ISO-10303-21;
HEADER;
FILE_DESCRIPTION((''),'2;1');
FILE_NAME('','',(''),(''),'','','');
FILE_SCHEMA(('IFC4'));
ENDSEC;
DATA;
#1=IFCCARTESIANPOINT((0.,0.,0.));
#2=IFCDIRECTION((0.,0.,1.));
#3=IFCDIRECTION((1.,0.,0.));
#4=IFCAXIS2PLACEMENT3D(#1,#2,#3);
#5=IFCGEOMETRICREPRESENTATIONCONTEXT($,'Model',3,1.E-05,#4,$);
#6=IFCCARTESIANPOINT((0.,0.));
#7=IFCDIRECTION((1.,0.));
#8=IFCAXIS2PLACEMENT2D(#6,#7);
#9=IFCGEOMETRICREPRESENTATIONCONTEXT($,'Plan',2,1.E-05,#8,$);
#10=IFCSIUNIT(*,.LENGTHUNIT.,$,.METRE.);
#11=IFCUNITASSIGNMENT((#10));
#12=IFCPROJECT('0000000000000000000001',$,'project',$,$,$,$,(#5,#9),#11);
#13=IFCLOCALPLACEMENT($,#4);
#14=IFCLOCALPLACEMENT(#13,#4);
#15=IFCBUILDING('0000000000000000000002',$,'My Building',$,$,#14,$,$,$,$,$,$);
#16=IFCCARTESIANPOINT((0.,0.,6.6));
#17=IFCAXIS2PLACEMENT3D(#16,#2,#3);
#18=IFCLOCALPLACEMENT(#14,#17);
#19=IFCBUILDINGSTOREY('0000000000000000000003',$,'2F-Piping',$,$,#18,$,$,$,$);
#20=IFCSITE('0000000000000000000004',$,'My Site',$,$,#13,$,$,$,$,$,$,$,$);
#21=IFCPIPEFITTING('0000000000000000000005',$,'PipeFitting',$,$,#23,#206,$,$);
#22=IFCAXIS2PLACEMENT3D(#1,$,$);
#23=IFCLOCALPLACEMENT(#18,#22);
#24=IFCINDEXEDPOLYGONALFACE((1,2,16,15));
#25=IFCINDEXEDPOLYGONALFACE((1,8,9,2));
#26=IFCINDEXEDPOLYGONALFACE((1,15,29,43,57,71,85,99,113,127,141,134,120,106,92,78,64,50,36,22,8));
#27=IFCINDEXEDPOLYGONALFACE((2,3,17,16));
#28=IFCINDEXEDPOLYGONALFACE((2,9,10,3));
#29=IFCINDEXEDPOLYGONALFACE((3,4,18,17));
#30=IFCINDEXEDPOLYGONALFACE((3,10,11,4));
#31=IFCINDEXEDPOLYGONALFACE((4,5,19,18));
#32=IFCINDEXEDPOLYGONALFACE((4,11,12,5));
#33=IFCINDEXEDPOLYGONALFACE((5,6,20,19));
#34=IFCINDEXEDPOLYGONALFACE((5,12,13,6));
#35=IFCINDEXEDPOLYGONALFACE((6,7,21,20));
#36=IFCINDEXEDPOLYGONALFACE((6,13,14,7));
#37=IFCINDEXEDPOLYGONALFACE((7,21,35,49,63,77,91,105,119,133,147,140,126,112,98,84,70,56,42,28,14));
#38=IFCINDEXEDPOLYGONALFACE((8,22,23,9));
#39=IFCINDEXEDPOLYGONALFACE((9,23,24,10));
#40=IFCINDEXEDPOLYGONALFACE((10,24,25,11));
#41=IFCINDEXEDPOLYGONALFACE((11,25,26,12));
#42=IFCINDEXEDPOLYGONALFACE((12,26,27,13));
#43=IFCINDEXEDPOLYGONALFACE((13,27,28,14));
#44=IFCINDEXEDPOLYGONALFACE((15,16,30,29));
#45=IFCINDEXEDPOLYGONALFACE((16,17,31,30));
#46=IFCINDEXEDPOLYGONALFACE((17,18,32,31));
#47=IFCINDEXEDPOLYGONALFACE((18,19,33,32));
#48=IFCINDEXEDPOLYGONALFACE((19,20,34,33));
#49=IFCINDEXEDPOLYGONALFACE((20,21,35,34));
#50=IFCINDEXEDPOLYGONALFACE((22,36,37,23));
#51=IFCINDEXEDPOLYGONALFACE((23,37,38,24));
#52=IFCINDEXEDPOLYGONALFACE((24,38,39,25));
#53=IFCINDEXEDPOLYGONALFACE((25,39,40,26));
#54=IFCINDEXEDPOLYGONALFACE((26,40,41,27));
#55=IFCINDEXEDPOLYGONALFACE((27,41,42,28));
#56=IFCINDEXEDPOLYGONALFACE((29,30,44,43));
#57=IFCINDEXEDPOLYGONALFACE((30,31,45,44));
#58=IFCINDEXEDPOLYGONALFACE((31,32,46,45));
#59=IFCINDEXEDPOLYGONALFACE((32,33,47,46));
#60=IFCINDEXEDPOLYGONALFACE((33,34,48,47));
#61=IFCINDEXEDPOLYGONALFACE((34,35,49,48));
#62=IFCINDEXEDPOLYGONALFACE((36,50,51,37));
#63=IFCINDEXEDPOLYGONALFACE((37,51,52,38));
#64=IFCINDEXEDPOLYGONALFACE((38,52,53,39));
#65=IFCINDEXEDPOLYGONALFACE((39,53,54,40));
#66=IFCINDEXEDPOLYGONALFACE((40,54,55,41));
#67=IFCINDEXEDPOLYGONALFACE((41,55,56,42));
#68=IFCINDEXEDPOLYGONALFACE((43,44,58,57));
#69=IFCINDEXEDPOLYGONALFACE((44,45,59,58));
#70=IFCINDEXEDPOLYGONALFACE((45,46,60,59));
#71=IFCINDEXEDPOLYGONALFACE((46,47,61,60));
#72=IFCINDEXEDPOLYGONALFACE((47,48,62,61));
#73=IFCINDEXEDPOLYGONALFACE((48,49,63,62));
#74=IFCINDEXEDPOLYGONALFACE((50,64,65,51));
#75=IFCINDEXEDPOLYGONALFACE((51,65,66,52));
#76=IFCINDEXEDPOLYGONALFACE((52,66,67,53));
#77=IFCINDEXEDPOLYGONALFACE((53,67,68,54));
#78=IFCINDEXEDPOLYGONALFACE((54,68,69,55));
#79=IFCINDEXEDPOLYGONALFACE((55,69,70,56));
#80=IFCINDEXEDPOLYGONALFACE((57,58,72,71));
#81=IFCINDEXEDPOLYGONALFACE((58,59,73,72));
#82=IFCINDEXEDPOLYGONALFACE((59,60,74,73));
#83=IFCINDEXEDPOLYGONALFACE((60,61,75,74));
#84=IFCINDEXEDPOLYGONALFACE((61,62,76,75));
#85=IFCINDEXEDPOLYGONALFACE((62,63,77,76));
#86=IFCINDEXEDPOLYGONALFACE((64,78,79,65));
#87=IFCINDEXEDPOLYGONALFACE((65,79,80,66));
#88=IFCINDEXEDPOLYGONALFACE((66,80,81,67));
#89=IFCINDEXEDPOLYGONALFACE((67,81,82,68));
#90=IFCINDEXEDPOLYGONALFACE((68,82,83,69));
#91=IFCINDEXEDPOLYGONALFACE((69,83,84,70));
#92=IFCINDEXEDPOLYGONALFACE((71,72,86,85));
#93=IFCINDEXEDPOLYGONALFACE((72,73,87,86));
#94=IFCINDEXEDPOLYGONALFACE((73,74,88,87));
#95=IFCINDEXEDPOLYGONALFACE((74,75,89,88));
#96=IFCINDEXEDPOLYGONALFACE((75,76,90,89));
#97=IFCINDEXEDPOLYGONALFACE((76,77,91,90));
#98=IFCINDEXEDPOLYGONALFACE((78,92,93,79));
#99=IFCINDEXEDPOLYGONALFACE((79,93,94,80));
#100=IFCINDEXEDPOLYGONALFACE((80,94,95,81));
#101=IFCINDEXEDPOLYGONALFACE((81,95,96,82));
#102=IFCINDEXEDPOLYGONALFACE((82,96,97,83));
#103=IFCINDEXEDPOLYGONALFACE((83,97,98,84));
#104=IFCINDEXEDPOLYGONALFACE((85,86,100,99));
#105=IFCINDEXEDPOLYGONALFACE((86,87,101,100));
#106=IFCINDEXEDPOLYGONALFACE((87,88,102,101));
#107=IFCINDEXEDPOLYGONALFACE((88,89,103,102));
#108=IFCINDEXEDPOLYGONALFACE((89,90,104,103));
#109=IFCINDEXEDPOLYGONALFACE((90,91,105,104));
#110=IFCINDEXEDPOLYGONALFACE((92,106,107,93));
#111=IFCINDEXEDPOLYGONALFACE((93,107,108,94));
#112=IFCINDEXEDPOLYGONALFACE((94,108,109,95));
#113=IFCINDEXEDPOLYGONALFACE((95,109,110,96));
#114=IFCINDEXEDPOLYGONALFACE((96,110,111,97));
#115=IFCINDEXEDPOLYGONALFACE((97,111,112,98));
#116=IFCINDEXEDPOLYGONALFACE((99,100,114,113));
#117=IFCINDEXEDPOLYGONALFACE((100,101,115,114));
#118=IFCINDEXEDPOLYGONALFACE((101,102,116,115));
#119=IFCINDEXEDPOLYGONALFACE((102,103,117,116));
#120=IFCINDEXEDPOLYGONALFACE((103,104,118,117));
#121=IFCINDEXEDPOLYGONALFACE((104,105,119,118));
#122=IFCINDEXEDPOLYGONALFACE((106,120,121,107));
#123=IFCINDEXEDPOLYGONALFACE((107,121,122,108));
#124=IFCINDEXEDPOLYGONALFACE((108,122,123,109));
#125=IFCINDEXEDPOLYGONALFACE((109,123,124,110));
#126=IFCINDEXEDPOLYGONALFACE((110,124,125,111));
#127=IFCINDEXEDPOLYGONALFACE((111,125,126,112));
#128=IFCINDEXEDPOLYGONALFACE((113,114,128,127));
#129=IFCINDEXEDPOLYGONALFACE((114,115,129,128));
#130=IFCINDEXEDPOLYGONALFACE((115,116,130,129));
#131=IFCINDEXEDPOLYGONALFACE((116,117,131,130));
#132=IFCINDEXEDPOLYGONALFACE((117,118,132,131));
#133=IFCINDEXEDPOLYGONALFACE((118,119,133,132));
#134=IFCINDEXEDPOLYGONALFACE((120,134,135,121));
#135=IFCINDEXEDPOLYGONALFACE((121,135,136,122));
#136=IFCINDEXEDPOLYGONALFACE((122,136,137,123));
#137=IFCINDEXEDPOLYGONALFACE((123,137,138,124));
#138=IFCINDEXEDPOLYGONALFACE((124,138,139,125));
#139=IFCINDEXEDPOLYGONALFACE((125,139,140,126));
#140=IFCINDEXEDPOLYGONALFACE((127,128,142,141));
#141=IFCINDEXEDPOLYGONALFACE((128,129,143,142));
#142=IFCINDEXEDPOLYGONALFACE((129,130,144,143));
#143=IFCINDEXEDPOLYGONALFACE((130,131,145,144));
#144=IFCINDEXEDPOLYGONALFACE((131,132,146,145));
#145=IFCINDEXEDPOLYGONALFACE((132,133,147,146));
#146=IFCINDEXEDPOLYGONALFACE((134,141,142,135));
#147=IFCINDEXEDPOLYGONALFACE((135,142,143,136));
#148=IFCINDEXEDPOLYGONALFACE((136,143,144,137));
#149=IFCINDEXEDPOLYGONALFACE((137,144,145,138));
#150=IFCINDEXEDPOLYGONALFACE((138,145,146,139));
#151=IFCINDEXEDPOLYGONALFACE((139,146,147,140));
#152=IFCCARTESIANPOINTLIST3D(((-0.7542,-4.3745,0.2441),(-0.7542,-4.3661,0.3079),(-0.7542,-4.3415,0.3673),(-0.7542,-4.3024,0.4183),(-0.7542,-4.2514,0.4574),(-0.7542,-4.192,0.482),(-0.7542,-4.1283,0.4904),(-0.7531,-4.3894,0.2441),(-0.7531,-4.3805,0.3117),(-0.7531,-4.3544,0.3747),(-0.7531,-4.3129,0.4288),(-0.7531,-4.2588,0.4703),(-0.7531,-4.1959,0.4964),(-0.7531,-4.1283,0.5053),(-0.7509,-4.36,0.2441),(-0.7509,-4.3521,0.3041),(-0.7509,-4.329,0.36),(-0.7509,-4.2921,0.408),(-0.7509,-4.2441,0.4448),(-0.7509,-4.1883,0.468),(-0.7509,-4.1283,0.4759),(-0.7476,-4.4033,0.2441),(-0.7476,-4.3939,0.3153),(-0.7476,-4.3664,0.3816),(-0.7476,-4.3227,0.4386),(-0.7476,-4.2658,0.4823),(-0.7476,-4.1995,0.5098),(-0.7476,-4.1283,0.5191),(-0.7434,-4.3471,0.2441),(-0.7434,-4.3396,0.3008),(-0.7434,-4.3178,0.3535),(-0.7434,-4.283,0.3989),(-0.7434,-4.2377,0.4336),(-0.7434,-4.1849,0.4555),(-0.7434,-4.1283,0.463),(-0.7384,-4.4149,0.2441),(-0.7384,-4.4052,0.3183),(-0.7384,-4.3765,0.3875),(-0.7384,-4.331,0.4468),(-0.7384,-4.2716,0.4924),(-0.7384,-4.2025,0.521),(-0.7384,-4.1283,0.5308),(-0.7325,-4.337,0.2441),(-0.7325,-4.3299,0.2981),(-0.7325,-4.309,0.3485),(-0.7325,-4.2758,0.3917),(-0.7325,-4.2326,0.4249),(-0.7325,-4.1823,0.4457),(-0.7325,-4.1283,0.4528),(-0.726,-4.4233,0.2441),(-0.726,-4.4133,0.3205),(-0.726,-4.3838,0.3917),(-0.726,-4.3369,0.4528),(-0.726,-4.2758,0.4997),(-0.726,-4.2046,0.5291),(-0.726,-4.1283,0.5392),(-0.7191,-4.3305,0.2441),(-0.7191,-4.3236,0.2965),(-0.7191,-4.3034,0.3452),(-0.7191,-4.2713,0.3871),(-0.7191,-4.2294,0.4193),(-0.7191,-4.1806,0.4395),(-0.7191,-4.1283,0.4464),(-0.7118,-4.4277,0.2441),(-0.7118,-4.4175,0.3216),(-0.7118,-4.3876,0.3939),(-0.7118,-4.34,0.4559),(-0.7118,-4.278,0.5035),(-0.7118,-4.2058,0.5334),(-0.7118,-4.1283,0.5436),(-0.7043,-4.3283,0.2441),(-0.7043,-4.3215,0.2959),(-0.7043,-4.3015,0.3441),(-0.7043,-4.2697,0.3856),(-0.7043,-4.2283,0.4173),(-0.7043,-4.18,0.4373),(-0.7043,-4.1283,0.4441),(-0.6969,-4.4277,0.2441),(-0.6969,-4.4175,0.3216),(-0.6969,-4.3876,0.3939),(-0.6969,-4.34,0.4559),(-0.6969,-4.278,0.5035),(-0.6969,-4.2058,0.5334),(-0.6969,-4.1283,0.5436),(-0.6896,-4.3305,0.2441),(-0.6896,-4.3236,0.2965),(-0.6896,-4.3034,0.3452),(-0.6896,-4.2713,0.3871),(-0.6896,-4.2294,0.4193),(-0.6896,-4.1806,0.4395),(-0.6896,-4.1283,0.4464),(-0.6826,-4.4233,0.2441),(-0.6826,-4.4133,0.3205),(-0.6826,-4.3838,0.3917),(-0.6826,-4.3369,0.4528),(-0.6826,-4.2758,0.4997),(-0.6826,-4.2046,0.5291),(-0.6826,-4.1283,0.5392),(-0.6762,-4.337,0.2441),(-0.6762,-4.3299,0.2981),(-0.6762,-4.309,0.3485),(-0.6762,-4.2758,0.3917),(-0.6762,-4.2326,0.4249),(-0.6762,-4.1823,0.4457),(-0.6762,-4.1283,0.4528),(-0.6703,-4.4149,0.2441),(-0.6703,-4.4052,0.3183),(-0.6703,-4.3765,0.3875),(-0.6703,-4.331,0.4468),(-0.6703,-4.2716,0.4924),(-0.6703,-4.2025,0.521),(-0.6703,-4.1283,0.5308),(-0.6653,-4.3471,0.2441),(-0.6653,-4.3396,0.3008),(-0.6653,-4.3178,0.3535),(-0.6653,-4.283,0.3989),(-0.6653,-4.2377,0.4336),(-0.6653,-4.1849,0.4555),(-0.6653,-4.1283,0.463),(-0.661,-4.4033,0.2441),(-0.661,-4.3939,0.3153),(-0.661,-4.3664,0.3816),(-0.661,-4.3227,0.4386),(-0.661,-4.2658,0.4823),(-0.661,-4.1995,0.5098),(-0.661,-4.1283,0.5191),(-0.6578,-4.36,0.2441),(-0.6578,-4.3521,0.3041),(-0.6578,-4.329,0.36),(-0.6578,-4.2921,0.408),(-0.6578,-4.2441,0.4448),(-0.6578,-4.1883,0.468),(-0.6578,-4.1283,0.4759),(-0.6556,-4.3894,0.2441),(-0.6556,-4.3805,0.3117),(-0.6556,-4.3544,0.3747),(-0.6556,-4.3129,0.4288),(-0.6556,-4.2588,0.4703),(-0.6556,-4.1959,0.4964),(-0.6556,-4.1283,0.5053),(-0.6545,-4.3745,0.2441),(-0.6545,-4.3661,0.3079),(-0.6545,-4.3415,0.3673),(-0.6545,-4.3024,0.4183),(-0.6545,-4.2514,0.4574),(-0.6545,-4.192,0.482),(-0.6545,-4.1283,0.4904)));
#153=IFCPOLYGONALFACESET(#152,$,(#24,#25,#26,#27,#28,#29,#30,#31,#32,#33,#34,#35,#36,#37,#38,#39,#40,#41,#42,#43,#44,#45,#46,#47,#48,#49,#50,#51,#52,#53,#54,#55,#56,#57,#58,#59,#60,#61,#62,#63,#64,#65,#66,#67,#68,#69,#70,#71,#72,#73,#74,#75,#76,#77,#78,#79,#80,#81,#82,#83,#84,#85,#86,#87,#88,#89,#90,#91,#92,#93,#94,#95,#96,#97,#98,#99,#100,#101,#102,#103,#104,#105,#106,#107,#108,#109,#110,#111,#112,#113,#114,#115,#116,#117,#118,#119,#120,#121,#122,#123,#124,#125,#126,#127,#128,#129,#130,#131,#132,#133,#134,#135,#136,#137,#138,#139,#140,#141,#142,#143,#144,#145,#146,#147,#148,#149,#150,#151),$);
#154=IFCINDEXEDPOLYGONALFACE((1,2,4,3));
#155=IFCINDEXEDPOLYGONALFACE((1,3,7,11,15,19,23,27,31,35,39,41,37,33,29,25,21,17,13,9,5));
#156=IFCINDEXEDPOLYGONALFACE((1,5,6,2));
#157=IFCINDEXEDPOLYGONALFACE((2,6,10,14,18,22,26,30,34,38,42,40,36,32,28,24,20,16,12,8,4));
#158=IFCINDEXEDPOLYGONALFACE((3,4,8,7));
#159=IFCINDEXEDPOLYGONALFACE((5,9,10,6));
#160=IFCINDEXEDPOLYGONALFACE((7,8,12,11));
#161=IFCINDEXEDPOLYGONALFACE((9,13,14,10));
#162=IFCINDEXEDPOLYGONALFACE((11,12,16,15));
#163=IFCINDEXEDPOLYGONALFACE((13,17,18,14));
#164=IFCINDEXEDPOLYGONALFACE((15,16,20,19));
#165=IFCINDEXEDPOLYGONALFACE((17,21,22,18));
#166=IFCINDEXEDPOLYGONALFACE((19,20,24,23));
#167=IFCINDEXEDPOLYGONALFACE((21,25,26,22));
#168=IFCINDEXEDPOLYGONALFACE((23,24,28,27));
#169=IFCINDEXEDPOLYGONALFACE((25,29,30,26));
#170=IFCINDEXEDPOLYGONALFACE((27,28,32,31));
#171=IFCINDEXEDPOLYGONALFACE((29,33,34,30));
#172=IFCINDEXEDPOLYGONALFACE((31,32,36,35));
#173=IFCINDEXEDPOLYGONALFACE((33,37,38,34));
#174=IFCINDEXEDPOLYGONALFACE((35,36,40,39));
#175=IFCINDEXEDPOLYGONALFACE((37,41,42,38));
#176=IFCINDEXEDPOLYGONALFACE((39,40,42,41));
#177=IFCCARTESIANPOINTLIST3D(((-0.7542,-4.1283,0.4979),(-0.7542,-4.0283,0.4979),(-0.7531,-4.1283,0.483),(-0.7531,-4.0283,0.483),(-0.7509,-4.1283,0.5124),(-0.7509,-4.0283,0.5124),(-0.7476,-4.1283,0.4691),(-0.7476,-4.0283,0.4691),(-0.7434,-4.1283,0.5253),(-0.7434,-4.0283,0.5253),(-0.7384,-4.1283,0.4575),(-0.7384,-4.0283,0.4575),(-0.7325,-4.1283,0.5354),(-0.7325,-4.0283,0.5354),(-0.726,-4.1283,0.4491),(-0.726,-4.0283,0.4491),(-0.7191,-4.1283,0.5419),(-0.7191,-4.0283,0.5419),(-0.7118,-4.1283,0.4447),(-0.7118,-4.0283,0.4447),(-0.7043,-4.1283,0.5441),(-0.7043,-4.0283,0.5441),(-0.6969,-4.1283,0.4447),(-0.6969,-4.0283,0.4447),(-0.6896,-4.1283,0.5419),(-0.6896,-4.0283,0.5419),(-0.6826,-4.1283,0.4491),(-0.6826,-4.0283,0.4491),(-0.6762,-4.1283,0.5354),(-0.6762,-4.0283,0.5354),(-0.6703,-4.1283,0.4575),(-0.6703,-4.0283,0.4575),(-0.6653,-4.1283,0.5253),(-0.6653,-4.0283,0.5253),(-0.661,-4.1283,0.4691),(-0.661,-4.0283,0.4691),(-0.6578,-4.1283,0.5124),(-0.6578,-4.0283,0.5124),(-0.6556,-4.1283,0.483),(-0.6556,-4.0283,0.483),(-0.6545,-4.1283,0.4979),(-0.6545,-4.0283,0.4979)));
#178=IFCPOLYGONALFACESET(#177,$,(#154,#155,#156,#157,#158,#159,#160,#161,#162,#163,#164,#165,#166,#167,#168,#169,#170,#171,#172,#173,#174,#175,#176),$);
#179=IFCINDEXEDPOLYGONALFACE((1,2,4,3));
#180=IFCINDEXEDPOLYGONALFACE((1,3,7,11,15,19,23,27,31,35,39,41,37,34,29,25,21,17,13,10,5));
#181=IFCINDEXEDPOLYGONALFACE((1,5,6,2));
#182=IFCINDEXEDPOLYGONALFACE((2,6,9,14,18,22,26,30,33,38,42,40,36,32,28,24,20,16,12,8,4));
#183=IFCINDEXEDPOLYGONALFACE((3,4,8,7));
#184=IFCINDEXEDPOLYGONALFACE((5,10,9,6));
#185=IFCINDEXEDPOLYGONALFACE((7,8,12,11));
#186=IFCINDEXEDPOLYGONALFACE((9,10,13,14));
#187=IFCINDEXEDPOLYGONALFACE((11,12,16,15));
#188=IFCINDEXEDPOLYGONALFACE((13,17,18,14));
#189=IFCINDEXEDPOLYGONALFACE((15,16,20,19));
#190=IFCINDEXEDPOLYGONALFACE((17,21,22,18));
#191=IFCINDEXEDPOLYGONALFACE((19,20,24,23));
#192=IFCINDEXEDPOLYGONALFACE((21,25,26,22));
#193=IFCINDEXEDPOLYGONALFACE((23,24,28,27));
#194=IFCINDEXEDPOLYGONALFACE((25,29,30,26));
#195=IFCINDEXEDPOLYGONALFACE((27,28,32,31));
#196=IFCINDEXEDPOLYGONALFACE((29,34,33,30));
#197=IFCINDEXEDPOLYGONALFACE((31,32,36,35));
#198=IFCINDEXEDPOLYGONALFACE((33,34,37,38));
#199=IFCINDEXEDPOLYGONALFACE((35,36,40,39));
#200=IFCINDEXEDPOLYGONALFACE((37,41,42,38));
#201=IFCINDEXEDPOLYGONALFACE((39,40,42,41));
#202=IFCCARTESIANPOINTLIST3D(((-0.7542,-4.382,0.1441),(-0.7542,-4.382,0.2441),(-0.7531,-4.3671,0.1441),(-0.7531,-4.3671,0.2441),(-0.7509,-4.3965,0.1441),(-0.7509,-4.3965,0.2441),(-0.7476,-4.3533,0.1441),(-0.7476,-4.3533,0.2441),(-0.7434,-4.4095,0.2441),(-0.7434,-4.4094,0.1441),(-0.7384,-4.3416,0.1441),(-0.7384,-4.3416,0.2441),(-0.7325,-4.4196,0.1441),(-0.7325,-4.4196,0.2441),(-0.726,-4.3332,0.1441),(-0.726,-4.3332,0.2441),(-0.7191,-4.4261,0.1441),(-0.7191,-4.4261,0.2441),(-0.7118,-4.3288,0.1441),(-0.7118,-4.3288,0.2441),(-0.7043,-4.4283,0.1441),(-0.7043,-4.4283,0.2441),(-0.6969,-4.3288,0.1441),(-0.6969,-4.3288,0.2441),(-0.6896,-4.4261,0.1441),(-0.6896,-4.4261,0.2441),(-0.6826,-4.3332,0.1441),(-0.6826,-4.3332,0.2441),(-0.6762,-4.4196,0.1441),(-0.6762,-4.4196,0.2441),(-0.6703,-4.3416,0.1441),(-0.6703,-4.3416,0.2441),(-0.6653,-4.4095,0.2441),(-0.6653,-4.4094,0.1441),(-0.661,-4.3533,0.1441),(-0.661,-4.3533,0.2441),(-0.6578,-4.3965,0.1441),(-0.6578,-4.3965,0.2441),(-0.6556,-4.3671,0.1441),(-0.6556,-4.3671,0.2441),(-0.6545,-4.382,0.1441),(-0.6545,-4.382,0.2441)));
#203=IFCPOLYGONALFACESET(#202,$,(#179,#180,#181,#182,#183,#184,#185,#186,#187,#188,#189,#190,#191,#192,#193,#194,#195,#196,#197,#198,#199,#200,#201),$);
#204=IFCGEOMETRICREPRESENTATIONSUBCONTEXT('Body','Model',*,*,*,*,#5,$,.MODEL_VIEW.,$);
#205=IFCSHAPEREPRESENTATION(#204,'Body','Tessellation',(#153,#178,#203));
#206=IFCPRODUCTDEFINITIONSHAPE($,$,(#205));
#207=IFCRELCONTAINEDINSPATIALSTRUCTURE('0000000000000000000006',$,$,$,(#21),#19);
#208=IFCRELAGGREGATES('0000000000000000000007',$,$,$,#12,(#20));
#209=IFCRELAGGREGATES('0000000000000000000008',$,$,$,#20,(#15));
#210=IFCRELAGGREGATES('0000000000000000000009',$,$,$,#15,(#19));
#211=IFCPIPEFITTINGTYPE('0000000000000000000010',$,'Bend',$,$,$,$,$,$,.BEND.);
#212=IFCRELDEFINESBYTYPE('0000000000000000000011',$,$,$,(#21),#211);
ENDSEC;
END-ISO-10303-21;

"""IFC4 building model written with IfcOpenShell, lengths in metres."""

from ifc_helpers import new_model, entity, si_unit, frame, origin_with_axes, origin_2d_with_axis, place, context, subcontext, project, spatial, circle, extrude, source, transform, mapped, type_object, type_shapes, element, save


model = new_model("IFC4")

# Units and contexts
model_context = context("Model", 3, precision=1e-05, world=origin_with_axes())
plan_context = context("Plan", 2, precision=1e-05, world=origin_2d_with_axis())
body_context = subcontext(model_context, "Body", "Model", "MODEL_VIEW")
ifc_project = project(units=[si_unit("LENGTHUNIT", "METRE")], contexts=[model_context, plan_context])

# Site, building, storey
site_placement = place(None, origin_with_axes())
site = spatial("IfcSite", under=ifc_project, at=site_placement, Name="My Site")
building_placement = place(site_placement, origin_with_axes())
building = spatial("IfcBuilding", under=site, at=building_placement, Name="My Building")
storey_placement = place(building_placement, frame((0.0, 0.0, 6.6), z_axis=(0.0, 0.0, 1.0), x_axis=(1.0, 0.0, 0.0)))
storey = spatial("IfcBuildingStorey", under=building, at=storey_placement, Name="2F-Piping")

# Pipe fitting
pipe_fitting_type = type_object("IfcPipeFittingType", Name="Bend", PredefinedType="BEND")
shared_shape = source(origin_with_axes(), body_context, "Body", "SolidModel", [
    entity("IfcSweptDiskSolid", entity("IfcIndexedPolyCurve", entity("IfcCartesianPointList3D", [[0.0, 0.0, -0.1], [-0.0732, 0.0, -0.2768], [-0.25, 0.0, -0.35]]), [entity("IfcArcIndex", [1, 2, 3])]), 0.05),
    extrude(circle(Radius=0.05), origin_with_axes(), (0.0, 0.0, -1.0), 0.1),
    extrude(circle(Radius=0.05), frame((-0.25, 0.0, -0.35), z_axis=(-1.0, 0.0, 0.0), x_axis=(0.0, 0.0, -1.0)), (0.0, 0.0, 1.0), 0.1),
])
type_shapes(pipe_fitting_type, [shared_shape])
for number, where, z_axis, x_axis, name in (
    (1, (-0.7043, -4.0283, 0.4941), (0.0, 1.0, 0.0), (0.0, 0.0, 1.0), "PipeFitting"),
):
    element("IfcPipeFitting", number, at=place(storey_placement, frame(where, z_axis=z_axis, x_axis=x_axis)), inside=storey, type_object=pipe_fitting_type, Name=name, context=body_context, shape_type="MappedRepresentation", body=[
        mapped(shared_shape, transform((0.0, 0.0, 0.0), x_axis=(1.0, 0.0, 0.0), y_axis=(0.0, 1.0, 0.0), z_axis=(0.0, 0.0, 1.0), scale=1.0)),
    ])

save(model, "model.ifc")
